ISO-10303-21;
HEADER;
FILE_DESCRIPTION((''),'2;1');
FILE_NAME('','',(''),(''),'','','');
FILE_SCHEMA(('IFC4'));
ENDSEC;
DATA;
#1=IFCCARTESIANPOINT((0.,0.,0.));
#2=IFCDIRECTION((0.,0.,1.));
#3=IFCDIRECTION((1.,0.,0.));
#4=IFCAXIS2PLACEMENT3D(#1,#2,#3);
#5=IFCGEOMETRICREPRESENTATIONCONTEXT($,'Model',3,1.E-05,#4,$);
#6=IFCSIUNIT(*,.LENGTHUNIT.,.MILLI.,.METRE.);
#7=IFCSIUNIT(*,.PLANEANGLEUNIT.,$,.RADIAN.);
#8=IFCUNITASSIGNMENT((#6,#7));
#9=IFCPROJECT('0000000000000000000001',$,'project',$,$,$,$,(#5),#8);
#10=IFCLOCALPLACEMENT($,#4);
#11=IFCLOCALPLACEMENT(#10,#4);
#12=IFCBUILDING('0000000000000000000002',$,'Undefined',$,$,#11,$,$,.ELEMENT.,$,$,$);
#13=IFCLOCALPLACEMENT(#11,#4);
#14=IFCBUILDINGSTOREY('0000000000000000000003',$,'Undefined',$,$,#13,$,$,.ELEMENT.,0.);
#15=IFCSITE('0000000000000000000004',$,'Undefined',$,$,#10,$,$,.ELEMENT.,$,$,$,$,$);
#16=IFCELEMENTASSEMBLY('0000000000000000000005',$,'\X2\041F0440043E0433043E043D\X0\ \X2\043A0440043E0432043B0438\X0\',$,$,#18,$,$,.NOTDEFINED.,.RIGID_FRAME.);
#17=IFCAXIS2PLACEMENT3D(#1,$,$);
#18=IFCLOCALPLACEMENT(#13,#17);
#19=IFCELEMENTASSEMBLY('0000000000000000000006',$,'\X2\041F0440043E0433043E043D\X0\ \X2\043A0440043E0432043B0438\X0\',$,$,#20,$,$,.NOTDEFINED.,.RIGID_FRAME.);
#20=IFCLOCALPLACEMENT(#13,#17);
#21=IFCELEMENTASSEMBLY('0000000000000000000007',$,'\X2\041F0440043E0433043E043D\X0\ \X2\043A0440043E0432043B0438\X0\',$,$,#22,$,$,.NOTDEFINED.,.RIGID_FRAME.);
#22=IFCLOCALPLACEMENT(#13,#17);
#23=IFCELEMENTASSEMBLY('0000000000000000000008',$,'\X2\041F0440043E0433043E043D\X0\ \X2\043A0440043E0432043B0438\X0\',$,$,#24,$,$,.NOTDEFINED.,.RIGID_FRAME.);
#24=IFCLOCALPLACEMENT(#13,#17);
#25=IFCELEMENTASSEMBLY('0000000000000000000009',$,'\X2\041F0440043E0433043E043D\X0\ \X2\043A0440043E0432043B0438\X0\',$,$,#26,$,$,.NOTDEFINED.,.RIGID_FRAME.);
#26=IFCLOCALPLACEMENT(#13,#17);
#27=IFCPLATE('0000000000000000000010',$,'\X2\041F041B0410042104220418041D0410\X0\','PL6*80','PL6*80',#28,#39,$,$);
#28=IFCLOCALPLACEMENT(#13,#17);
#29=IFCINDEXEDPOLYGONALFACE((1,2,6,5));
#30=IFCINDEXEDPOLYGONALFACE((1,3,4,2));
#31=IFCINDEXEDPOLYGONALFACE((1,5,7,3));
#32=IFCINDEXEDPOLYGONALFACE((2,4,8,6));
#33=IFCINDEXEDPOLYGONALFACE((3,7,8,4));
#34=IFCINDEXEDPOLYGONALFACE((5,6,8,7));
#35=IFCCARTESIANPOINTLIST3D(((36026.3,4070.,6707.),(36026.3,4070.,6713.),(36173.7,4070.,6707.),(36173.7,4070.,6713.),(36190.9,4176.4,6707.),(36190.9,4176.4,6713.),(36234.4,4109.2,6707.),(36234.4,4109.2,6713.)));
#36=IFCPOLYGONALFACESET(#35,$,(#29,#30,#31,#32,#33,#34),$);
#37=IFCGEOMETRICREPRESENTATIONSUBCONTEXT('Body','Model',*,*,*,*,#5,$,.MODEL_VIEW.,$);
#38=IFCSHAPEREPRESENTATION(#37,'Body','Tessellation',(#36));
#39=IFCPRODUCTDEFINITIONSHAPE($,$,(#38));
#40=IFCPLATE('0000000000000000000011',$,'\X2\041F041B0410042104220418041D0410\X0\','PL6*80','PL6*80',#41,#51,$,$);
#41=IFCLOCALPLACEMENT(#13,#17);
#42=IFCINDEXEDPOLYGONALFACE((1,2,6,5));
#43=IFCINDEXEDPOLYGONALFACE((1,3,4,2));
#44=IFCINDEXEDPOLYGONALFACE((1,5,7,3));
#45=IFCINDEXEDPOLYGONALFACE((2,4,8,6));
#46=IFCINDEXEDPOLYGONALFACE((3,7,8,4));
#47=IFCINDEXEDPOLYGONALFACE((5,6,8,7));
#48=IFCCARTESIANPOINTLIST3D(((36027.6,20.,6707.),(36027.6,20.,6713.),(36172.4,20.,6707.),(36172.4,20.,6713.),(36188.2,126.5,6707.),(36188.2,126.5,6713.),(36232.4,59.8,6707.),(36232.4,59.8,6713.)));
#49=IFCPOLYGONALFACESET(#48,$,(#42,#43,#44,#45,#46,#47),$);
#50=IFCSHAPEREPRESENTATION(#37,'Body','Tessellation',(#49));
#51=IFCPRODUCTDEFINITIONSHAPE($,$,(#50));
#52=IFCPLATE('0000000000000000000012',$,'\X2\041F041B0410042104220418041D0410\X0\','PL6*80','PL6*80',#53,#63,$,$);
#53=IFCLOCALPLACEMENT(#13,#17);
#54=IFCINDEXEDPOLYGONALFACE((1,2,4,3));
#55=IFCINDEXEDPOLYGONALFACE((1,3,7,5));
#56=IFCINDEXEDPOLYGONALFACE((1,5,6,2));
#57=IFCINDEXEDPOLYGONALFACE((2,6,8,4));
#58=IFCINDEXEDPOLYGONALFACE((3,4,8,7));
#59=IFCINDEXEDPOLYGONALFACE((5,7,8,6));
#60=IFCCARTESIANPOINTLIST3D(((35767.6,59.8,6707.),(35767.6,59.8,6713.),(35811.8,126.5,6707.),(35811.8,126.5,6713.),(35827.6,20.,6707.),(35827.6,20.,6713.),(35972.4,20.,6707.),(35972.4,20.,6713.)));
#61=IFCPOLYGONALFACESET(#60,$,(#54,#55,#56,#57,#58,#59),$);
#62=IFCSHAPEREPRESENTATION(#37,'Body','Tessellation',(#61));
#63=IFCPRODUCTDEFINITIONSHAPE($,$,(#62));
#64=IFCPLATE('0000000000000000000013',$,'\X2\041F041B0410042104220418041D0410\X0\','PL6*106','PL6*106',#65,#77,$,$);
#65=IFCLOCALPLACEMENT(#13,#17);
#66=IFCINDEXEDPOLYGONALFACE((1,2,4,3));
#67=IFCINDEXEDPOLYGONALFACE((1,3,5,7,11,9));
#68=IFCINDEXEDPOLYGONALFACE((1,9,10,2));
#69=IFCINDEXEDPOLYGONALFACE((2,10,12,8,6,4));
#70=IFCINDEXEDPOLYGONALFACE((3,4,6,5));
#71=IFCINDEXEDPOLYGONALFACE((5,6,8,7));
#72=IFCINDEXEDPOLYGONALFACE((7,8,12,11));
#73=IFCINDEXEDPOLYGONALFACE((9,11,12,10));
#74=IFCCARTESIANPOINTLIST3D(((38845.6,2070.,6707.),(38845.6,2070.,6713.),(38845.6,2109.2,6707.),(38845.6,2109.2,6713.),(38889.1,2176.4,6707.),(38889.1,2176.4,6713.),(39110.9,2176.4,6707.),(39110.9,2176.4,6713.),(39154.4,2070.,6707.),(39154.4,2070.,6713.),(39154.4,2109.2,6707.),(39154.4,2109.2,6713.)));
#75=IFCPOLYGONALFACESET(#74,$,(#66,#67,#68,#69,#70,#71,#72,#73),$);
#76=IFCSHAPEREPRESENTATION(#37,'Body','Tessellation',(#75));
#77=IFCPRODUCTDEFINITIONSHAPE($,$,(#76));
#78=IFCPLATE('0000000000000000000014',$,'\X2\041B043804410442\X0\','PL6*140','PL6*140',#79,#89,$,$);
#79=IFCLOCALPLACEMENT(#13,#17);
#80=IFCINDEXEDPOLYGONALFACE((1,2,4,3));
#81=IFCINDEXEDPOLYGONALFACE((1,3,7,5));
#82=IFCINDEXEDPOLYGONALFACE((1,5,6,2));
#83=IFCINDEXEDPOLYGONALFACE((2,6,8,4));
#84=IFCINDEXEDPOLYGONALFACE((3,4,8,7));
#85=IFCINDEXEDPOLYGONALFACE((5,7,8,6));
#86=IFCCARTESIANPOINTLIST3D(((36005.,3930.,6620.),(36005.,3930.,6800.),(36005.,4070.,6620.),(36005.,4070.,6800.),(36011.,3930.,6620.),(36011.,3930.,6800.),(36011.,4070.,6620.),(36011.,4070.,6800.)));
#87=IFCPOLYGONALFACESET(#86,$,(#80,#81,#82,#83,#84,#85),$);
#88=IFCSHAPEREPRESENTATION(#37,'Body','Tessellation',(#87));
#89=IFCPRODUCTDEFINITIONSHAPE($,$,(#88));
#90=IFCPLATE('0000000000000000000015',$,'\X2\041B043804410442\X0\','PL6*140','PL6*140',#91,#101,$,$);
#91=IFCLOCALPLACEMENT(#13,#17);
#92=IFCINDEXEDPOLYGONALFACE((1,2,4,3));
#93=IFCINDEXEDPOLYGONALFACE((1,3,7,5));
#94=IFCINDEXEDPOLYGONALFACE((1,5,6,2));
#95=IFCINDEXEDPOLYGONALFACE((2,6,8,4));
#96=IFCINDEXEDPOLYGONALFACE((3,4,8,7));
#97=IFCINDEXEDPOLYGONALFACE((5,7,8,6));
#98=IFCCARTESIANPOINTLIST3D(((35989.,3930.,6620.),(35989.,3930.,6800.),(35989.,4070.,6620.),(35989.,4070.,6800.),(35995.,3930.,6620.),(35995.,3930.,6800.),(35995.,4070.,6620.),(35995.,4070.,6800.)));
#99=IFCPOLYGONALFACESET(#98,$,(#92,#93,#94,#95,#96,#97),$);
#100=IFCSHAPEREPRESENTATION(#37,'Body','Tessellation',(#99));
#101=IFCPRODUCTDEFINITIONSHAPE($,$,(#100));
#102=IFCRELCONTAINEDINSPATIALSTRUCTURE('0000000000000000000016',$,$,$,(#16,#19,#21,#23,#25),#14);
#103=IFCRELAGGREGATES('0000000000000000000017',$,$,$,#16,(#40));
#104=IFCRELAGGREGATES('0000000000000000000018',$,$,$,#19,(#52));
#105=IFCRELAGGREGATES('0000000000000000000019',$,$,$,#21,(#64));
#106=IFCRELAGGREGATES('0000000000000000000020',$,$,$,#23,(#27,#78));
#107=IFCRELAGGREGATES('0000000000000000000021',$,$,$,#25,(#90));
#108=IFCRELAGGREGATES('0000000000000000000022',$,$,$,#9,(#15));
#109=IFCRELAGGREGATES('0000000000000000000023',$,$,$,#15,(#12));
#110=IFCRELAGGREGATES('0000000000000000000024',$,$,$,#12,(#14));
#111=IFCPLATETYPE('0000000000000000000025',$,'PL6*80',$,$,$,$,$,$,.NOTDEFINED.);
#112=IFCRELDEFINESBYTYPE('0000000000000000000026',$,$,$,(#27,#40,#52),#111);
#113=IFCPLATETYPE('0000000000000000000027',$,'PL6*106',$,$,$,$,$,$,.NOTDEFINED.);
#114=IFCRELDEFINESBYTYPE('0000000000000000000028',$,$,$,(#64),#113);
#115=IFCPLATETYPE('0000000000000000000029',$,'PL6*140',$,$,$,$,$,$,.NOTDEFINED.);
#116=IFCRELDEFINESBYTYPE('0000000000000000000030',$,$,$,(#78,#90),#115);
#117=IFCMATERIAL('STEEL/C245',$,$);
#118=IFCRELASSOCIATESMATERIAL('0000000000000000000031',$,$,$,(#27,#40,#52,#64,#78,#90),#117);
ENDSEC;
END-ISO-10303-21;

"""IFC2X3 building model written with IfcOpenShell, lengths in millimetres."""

from ifc_helpers import new_model, si_unit, frame, origin_with_axes, place, context, subcontext, project, spatial, polyline, outline, extrude, material, type_object, element, aggregate, save


model = new_model("IFC2X3")

# Units and contexts
model_context = context("Model", 3, precision=1e-05, world=origin_with_axes())
body_context = subcontext(model_context, "Body", "Model", "MODEL_VIEW")
ifc_project = project(units=[si_unit("LENGTHUNIT", "METRE", prefix="MILLI"), si_unit("PLANEANGLEUNIT", "RADIAN")], contexts=[model_context])

# Site, building, storey
site_placement = place(None, origin_with_axes())
site = spatial("IfcSite", under=ifc_project, at=site_placement, Name="Undefined", CompositionType="ELEMENT")
building_placement = place(site_placement, origin_with_axes())
building = spatial("IfcBuilding", under=site, at=building_placement, Name="Undefined", CompositionType="ELEMENT")
storey_placement = place(building_placement, origin_with_axes())
storey = spatial("IfcBuildingStorey", under=building, at=storey_placement, Name="Undefined", CompositionType="ELEMENT", Elevation=0.0)

# Element assemblies
assembly_1_placement = place(storey_placement, origin_with_axes())
assembly_1 = element("IfcElementAssembly", 1, at=assembly_1_placement, inside=storey, Name="Прогон кровли", AssemblyPlace="NOTDEFINED", PredefinedType="RIGID_FRAME")
ifc_material_1 = material(Name="STEEL/C245")
assembly_2_placement = place(storey_placement, origin_with_axes())
assembly_2 = element("IfcElementAssembly", 2, at=assembly_2_placement, inside=storey, Name="Прогон кровли", AssemblyPlace="NOTDEFINED", PredefinedType="RIGID_FRAME")

# Element assemblies
assembly_3_placement = place(storey_placement, origin_with_axes())
assembly_3 = element("IfcElementAssembly", 3, at=assembly_3_placement, inside=storey, Name="Прогон кровли", AssemblyPlace="NOTDEFINED", PredefinedType="RIGID_FRAME")
assembly_4_placement = place(storey_placement, origin_with_axes())
assembly_4 = element("IfcElementAssembly", 4, at=assembly_4_placement, inside=storey, Name="Прогон кровли", AssemblyPlace="NOTDEFINED", PredefinedType="RIGID_FRAME")
assembly_5_placement = place(storey_placement, origin_with_axes())
assembly_5 = element("IfcElementAssembly", 5, at=assembly_5_placement, inside=storey, Name="Прогон кровли", AssemblyPlace="NOTDEFINED", PredefinedType="RIGID_FRAME")

# Plates
plate_type_1 = type_object("IfcPlateType", Name="PL6*80", PredefinedType="NOTDEFINED")
plate_1_placement = place(assembly_4_placement, frame((36026.3, 4070.0, 6710.0), z_axis=(0.0, 0.0, -1.0), x_axis=(0.840039, 0.542525, 0.0)))
plate_1 = element("IfcPlate", 6, at=plate_1_placement, type_object=plate_type_1, material=ifc_material_1, Name="ПЛАСТИНА", Description="PL6*80", ObjectType="PL6*80", context=body_context, shape_type="SweptSolid", body=[
    extrude(outline(polyline([(0.0, 0.0), (196.0, 0.0), (196.0, 80.0), (123.9, 80.0), (0.0, 0.0)])), frame((0.0, 0.0, -3.0), z_axis=(0.0, 0.0, 1.0), x_axis=(1.0, 0.0, 0.0)), (0.0, 0.0, 1.0), 6.0),
])
plate_2_placement = place(assembly_1_placement, frame((36027.6, 20.0, 6710.0), z_axis=(0.0, 0.0, -1.0), x_axis=(0.833383, 0.552695, 0.0)))
plate_2 = element("IfcPlate", 7, at=plate_2_placement, type_object=plate_type_1, material=ifc_material_1, Name="ПЛАСТИНА", Description="PL6*80", ObjectType="PL6*80", context=body_context, shape_type="SweptSolid", body=[
    extrude(outline(polyline([(0.0, 0.0), (192.7, 0.0), (192.7, 80.0), (120.6, 80.0), (0.0, 0.0)])), frame((0.0, 0.0, -3.0), z_axis=(0.0, 0.0, 1.0), x_axis=(1.0, 0.0, 0.0)), (0.0, 0.0, 1.0), 6.0),
])
aggregate(assembly_1, [plate_2])
plate_3_placement = place(assembly_2_placement, frame((35972.4, 20.0, 6710.0), z_axis=(0.0, 0.0, 1.0), x_axis=(-0.833383, 0.552695, 0.0)))
plate_3 = element("IfcPlate", 8, at=plate_3_placement, type_object=plate_type_1, material=ifc_material_1, Name="ПЛАСТИНА", Description="PL6*80", ObjectType="PL6*80", context=body_context, shape_type="SweptSolid", body=[
    extrude(outline(polyline([(0.0, 0.0), (192.7, 0.0), (192.7, 80.0), (120.6, 80.0), (0.0, 0.0)])), frame((0.0, 0.0, -3.0), z_axis=(0.0, 0.0, 1.0), x_axis=(1.0, 0.0, 0.0)), (0.0, 0.0, 1.0), 6.0),
])
aggregate(assembly_2, [plate_3])
plate_type_2 = type_object("IfcPlateType", Name="PL6*106", PredefinedType="NOTDEFINED")
plate_4_placement = place(assembly_3_placement, frame((38845.6, 2070.0, 6710.0), z_axis=(0.0, 0.0, -1.0), x_axis=(0.0, 1.0, 0.0)))
plate_4 = element("IfcPlate", 9, at=plate_4_placement, type_object=plate_type_2, material=ifc_material_1, Name="ПЛАСТИНА", Description="PL6*106", ObjectType="PL6*106", context=body_context, shape_type="SweptSolid", body=[
    extrude(outline(polyline([(0.0, 0.0), (39.2, 0.0), (106.4, 43.4), (106.4, 265.3), (39.2, 308.7), (0.0, 308.7), (0.0, 0.0)])), frame((0.0, 0.0, -3.0), z_axis=(0.0, 0.0, 1.0), x_axis=(1.0, 0.0, 0.0)), (0.0, 0.0, 1.0), 6.0),
])
aggregate(assembly_3, [plate_4])
plate_type_3 = type_object("IfcPlateType", Name="PL6*140", PredefinedType="NOTDEFINED")
plate_5_placement = place(assembly_4_placement, frame((36008.0, 4000.0, 6620.0), z_axis=(1.0, 0.0, 0.0), x_axis=(0.0, 0.0, 1.0)))
plate_5 = element("IfcPlate", 10, at=plate_5_placement, type_object=plate_type_3, material=ifc_material_1, Name="Лист", Description="PL6*140", ObjectType="PL6*140", context=body_context, shape_type="SweptSolid", body=[
    extrude(outline(polyline([(0.0, 70.0), (180.0, 70.0), (180.0, -70.0), (0.0, -70.0), (0.0, 70.0)])), frame((0.0, 0.0, -3.0), z_axis=(0.0, 0.0, 1.0), x_axis=(1.0, 0.0, 0.0)), (0.0, 0.0, 1.0), 6.0),
])
plate_6_placement = place(assembly_5_placement, frame((35992.0, 4000.0, 6620.0), z_axis=(-1.0, 0.0, 0.0), x_axis=(0.0, 0.0, 1.0)))
plate_6 = element("IfcPlate", 11, at=plate_6_placement, type_object=plate_type_3, material=ifc_material_1, Name="Лист", Description="PL6*140", ObjectType="PL6*140", context=body_context, shape_type="SweptSolid", body=[
    extrude(outline(polyline([(0.0, -70.0), (0.0, 70.0), (180.0, 70.0), (180.0, -70.0), (0.0, -70.0)])), frame((0.0, 0.0, -3.0), z_axis=(0.0, 0.0, 1.0), x_axis=(1.0, 0.0, 0.0)), (0.0, 0.0, 1.0), 6.0),
])

aggregate(assembly_4, [plate_1, plate_5])
aggregate(assembly_5, [plate_6])

save(model, "model.ifc")
